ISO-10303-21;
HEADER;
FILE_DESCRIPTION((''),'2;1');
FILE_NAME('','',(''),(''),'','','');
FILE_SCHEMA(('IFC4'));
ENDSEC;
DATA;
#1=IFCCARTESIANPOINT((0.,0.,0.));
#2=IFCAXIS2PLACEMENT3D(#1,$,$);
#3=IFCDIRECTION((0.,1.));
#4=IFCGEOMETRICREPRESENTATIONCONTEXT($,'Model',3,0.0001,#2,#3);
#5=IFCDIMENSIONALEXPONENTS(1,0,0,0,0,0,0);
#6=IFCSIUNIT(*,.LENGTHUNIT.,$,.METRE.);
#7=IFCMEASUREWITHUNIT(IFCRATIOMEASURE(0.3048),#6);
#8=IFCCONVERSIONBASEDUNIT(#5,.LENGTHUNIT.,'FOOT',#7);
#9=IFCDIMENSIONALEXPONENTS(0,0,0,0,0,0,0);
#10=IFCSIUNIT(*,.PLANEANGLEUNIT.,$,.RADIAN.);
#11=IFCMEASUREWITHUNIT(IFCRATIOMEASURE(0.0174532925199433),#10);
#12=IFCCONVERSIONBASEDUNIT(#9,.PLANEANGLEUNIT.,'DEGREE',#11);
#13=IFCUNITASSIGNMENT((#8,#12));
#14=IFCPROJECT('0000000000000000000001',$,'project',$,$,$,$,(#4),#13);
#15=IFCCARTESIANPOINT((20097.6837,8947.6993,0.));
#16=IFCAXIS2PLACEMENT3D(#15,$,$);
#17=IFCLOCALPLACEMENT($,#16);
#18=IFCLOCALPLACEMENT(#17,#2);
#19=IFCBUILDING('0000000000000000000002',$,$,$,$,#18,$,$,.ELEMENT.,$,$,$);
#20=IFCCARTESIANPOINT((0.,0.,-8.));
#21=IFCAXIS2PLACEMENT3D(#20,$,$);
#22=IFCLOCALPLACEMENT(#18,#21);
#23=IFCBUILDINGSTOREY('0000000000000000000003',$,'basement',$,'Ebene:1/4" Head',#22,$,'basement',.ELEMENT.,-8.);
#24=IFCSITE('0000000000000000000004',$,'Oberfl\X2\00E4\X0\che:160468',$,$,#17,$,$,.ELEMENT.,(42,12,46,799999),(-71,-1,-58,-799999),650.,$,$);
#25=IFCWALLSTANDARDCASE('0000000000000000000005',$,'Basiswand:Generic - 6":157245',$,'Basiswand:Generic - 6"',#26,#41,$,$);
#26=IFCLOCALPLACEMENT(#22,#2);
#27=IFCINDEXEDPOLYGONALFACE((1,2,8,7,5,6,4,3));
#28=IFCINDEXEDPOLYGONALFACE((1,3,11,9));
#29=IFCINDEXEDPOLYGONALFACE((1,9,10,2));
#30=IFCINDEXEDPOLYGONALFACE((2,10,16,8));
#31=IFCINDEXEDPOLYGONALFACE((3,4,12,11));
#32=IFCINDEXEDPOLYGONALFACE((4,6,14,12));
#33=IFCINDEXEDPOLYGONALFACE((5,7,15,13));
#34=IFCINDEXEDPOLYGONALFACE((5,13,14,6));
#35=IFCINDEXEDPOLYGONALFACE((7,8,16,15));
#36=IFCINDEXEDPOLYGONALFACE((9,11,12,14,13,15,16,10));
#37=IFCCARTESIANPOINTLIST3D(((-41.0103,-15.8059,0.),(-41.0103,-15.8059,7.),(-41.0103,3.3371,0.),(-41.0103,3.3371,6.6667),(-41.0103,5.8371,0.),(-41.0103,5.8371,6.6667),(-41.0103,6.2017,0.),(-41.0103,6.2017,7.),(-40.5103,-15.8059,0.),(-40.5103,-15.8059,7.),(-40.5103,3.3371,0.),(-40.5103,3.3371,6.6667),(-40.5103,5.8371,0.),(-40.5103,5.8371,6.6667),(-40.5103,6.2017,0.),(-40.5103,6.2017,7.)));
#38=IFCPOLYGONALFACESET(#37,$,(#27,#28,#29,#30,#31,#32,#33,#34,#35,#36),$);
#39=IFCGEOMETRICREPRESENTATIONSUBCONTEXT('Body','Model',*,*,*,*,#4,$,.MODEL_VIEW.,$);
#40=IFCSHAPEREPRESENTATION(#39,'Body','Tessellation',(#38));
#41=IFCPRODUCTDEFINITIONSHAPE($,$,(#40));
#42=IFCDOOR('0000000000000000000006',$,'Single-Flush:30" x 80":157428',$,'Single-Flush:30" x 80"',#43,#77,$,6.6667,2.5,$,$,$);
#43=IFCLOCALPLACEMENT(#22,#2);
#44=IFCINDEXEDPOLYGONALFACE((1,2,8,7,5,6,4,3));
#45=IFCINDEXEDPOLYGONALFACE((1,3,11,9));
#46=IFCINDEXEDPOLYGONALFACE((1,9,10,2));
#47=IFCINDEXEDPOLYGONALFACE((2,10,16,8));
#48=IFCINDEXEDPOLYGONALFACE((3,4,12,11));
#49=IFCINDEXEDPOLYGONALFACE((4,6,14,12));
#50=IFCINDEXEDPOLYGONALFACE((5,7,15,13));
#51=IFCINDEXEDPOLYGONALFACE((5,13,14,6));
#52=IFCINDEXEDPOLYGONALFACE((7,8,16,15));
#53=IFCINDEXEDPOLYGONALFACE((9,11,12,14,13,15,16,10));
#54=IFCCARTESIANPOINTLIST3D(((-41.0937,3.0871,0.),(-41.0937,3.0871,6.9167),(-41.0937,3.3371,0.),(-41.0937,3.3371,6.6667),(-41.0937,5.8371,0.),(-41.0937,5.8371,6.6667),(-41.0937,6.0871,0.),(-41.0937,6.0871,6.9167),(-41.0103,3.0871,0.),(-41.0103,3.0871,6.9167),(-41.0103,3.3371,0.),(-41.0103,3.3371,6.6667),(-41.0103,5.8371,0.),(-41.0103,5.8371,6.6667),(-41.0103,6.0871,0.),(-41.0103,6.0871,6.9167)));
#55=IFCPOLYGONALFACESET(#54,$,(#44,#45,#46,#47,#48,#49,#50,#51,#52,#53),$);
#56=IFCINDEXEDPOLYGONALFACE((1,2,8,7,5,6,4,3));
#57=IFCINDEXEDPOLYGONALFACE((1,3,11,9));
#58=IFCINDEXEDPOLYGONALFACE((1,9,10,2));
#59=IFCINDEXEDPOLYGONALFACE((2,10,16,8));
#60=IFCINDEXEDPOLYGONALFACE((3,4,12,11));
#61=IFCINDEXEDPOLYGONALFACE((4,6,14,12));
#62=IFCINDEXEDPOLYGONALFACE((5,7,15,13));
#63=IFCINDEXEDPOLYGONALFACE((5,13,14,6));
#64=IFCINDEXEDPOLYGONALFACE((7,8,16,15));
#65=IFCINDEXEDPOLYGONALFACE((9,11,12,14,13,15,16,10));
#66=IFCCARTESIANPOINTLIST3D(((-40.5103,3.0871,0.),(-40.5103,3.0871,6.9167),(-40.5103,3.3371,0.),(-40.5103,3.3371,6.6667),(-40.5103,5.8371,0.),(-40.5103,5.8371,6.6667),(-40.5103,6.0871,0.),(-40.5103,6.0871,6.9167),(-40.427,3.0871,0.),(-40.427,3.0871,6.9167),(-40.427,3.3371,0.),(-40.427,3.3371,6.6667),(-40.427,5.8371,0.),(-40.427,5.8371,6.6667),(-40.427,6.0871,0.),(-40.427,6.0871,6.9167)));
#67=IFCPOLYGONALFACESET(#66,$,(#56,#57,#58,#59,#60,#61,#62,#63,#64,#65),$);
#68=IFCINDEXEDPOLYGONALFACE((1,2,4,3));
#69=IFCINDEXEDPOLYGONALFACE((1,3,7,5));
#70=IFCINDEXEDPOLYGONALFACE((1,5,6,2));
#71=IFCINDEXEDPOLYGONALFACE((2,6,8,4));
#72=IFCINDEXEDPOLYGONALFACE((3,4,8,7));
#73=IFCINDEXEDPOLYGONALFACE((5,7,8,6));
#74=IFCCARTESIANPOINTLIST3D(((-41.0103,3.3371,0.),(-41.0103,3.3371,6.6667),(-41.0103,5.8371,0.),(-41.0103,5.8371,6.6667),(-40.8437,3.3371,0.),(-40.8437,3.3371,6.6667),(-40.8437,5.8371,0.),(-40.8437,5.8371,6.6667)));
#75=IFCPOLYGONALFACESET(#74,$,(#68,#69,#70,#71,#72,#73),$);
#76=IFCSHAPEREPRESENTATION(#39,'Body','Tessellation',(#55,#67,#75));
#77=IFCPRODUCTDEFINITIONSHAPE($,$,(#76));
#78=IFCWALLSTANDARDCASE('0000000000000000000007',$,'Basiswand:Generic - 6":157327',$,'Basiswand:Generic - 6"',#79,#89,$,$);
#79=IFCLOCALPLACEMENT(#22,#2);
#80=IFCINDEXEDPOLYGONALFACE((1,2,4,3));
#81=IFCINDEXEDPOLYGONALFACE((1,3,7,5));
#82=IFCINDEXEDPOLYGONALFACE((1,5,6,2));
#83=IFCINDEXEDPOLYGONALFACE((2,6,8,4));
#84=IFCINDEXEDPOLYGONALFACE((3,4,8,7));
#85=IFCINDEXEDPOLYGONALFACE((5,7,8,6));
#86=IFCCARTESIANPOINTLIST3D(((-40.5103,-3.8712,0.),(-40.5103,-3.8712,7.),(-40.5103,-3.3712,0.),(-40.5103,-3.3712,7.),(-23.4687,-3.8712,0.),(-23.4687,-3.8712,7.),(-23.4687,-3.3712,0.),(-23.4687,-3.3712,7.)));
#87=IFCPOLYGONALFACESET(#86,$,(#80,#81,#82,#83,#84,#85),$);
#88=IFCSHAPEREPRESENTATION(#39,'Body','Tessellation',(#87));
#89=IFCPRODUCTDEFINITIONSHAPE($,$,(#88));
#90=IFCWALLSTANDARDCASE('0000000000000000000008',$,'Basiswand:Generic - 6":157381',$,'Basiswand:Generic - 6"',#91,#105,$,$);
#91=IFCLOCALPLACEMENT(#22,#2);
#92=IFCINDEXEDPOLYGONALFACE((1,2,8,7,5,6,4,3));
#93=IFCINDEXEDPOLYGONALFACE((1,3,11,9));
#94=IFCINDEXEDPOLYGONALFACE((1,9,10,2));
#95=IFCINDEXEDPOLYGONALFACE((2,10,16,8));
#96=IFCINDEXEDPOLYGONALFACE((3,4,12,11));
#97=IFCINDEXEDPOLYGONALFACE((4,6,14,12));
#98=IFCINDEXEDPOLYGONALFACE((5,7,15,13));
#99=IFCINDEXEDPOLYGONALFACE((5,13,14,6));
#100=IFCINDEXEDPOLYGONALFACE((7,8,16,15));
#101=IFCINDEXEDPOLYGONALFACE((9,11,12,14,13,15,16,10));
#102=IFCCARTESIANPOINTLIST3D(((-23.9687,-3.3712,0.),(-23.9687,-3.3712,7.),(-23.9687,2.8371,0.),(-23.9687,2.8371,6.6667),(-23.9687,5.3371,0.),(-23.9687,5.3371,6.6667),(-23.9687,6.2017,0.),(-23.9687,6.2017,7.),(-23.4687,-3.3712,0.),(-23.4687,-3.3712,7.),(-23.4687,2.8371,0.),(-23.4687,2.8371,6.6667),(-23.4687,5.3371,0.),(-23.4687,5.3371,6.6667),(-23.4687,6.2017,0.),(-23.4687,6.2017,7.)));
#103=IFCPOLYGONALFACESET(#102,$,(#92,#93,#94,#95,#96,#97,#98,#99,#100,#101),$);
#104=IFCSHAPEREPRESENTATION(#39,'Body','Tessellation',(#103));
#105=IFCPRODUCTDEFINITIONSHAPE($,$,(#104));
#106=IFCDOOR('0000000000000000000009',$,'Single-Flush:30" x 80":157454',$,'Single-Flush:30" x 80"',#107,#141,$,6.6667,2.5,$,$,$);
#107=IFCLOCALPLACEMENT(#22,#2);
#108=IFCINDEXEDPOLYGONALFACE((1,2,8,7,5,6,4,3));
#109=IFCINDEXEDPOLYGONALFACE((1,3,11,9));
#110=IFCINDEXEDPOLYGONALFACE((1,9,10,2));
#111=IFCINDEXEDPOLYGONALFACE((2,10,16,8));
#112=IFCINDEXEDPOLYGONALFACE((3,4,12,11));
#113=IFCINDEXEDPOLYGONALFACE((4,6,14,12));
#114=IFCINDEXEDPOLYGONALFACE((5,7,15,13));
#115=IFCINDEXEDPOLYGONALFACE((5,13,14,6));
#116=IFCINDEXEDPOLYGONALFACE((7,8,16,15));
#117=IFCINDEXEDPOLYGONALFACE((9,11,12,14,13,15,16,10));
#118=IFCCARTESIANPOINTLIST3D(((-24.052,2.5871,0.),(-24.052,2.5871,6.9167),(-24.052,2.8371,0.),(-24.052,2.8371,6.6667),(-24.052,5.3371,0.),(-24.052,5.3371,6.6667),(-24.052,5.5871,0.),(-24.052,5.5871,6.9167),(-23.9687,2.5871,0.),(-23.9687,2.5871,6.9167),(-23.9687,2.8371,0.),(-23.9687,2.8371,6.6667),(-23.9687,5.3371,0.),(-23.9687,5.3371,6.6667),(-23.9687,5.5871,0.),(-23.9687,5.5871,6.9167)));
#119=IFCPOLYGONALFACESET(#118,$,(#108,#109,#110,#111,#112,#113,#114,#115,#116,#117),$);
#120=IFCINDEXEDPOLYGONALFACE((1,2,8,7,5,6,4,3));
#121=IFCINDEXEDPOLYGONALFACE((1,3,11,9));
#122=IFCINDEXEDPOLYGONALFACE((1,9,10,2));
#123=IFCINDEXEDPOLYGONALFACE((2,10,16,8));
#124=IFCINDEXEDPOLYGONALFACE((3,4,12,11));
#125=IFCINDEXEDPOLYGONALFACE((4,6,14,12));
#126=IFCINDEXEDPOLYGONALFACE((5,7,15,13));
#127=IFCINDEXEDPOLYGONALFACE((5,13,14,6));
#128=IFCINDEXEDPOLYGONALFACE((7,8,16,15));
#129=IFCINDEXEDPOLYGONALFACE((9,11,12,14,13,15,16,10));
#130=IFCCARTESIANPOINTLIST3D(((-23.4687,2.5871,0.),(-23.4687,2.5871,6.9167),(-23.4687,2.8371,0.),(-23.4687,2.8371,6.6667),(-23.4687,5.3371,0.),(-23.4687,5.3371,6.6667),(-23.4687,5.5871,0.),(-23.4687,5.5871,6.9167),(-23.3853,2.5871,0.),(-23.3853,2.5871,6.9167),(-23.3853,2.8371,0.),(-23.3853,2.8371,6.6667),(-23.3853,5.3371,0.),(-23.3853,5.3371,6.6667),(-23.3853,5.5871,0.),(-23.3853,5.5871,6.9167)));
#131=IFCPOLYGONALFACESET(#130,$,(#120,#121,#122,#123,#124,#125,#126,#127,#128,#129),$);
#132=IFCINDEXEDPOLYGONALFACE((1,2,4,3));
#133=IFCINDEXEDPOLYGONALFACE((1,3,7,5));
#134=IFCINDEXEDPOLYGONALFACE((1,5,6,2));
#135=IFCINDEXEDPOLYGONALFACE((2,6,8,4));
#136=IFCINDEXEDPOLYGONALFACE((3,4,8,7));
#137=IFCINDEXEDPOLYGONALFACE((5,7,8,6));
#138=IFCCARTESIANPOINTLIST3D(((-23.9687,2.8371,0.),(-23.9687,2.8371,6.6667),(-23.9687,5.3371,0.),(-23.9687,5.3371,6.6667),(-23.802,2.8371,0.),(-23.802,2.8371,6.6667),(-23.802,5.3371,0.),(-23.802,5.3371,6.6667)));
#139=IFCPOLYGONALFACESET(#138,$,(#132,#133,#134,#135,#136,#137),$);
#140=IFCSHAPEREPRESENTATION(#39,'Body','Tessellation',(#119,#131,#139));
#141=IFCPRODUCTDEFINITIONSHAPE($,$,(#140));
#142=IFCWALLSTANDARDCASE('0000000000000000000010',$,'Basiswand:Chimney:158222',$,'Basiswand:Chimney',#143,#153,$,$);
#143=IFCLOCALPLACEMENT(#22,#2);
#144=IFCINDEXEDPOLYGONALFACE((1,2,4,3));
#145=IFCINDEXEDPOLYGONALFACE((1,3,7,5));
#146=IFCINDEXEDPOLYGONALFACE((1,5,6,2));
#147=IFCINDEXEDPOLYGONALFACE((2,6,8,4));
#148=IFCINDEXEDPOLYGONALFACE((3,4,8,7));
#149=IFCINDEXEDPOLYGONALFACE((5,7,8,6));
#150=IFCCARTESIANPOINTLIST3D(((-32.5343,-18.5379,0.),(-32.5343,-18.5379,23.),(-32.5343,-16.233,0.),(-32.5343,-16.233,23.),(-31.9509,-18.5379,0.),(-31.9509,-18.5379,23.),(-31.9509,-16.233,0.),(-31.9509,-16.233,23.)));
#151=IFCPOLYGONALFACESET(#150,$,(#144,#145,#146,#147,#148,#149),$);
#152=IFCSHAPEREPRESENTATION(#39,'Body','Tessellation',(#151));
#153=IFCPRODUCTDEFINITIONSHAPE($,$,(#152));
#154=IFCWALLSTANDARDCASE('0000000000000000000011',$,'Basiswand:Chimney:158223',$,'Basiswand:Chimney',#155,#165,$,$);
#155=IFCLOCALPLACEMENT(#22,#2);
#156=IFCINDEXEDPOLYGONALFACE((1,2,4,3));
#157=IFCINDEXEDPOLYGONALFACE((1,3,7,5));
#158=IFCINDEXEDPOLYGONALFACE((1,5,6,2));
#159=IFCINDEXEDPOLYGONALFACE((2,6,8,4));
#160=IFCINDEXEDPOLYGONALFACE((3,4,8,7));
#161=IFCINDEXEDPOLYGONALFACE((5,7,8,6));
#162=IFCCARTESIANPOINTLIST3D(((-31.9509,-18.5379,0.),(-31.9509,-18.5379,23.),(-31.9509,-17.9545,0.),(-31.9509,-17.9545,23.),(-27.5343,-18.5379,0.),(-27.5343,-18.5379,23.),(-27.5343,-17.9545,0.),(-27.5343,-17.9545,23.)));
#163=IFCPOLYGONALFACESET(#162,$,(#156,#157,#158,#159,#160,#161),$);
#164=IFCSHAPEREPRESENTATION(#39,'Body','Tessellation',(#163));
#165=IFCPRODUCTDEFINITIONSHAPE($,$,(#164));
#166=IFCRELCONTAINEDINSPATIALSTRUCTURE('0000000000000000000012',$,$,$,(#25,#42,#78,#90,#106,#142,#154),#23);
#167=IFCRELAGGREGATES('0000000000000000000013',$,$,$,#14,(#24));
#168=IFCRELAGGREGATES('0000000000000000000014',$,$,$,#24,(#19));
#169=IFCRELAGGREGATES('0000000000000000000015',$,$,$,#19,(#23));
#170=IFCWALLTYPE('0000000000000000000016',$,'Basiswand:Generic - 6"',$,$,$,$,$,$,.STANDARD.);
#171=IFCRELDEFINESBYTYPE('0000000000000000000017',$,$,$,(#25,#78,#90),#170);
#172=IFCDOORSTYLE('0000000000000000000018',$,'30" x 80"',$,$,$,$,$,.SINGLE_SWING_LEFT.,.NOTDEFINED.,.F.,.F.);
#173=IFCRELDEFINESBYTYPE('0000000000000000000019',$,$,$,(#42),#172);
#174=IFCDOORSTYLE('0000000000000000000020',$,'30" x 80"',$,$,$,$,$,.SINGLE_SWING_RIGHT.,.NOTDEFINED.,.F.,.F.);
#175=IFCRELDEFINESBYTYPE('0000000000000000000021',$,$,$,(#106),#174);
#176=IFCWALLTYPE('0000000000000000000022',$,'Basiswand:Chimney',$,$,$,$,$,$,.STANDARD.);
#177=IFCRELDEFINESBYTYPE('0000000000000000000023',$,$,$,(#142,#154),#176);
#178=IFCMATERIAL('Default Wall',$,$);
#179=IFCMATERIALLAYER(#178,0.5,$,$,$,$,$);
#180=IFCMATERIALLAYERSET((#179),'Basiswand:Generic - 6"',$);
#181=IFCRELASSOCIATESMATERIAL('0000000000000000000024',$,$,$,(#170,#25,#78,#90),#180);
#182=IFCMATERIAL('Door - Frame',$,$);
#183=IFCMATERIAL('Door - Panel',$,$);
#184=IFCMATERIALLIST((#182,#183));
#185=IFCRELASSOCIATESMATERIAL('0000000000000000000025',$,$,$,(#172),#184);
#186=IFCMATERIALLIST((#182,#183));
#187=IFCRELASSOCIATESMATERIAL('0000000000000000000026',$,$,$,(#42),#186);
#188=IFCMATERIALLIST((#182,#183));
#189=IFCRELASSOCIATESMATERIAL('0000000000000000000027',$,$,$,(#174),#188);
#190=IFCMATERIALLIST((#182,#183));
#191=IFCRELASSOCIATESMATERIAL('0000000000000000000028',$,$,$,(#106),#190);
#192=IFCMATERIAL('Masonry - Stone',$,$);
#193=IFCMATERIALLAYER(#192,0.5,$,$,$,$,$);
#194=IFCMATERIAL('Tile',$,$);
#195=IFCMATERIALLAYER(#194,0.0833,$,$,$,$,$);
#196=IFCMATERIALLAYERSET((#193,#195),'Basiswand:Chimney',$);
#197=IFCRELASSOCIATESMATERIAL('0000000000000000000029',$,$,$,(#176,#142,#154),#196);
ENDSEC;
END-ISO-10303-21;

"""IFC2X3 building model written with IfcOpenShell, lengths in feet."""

from ifc_helpers import new_model, entity, si_unit, converted_unit, direction, frame, frame_2d, origin, origin_2d_with_axis, place, context, subcontext, project, spatial, polyline, rectangle, outline, extrude, clip, bounded_halfspace, source, transform, mapped, material, material_list, layer, layer_set, layer_usage, type_object, type_shapes, element, fill, save


model = new_model("IFC2X3")

# Units and contexts
model_context = context("Model", 3, precision=0.0001, world=origin(), true_north=direction((0.0, 1.0)))
body_context = subcontext(model_context, "Body", "Model", "MODEL_VIEW")
ifc_project = project(units=[converted_unit("LENGTHUNIT", "FOOT", entity("IfcRatioMeasure", 0.3048), si_unit("LENGTHUNIT", "METRE"), dimensions=[1, 0, 0, 0, 0, 0, 0]), converted_unit("PLANEANGLEUNIT", "DEGREE", entity("IfcRatioMeasure", 0.0174532925199433), si_unit("PLANEANGLEUNIT", "RADIAN"), dimensions=[0, 0, 0, 0, 0, 0, 0])], contexts=[model_context])

# Site, building, storey
site_placement = place(None, frame((20097.6837, 8947.6993, 0.0)))
site = spatial("IfcSite", under=ifc_project, at=site_placement, Name="Oberfläche:160468", CompositionType="ELEMENT", RefLatitude=(42, 12, 46, 799999), RefLongitude=(-71, -1, -58, -799999), RefElevation=650.0)
building_placement = place(site_placement, origin())
building = spatial("IfcBuilding", under=site, at=building_placement, CompositionType="ELEMENT")
storey_placement = place(building_placement, frame((0.0, 0.0, -8.0)))
storey = spatial("IfcBuildingStorey", under=building, at=storey_placement, Name="basement", ObjectType="Ebene:1/4\" Head", LongName="basement", CompositionType="ELEMENT", Elevation=-8.0)

# Shared definitions
ifc_material_1 = material(Name="Door - Frame")
ifc_material_2 = material(Name="Door - Panel")

# Wall, opening, door
ifc_material_3 = material(Name="Default Wall")
ifc_layer_1 = layer(ifc_material_3, 0.5)
ifc_layer_set_1 = layer_set([ifc_layer_1], Name="Basiswand:Generic - 6\"")
ifc_layer_usage_1 = layer_usage(ifc_layer_set_1, "AXIS2", "NEGATIVE", 0.25)
wall_type_1 = type_object("IfcWallType", Name="Basiswand:Generic - 6\"", PredefinedType="STANDARD", material=ifc_layer_set_1)
wall_1_placement = place(storey_placement, frame((-40.7603, -15.8059, 0.0), z_axis=(0.0, 0.0, 1.0), x_axis=(0.0, 1.0, 0.0)))
wall_1 = element("IfcWallStandardCase", 1, at=wall_1_placement, inside=storey, type_object=wall_type_1, material=ifc_layer_usage_1, Name="Basiswand:Generic - 6\":157245", ObjectType="Basiswand:Generic - 6\"", context=body_context, shape_type="Clipping", body=[
    clip(extrude(rectangle(XDim=22.0076, YDim=0.5, at=frame_2d((11.0038, 0.0), x_axis=(-1.0, 0.0))), origin(), (0.0, 0.0, 1.0), 7.0), bounded_halfspace(frame((0.0, -0.25, 7.0), z_axis=(0.0, 0.0, -1.0), x_axis=(0.0, -1.0, 0.0)), True, frame((0.0, -0.25, 7.0)), polyline([(0.0, 0.0), (11.9347, 0.0), (12.4347, 0.0), (22.0076, 0.0), (22.0076, 0.5), (0.0, 0.5), (0.0, 0.0)]))),
])
opening_1_placement = place(wall_1_placement, frame((19.143, -0.25, 0.0)))
opening_1 = element("IfcOpeningElement", 2, at=opening_1_placement, cuts=wall_1, ObjectType="Opening", context=body_context, shape_type="SweptSolid", body=[
    extrude(rectangle(XDim=2.5, YDim=6.6667, at=frame_2d((3.3333, 1.25), x_axis=(0.0, -1.0))), frame((0.0, 0.0, 0.0), z_axis=(0.0, 1.0, 0.0), x_axis=(0.0, 0.0, 1.0)), (0.0, 0.0, 1.0), 0.5),
])
ifc_material_list_1 = material_list([ifc_material_1, ifc_material_2])
ifc_material_list_2 = material_list([ifc_material_1, ifc_material_2])
door_style_1 = type_object("IfcDoorStyle", Name="30\" x 80\"", ConstructionType="NOTDEFINED", OperationType="SINGLE_SWING_LEFT", ParameterTakesPrecedence=False, Sizeable=False, material=ifc_material_list_2)
shared_shape_1 = source(origin(), body_context, "Body", "SweptSolid", [
    extrude(outline(polyline([(-1.5, -3.5208), (1.5, -3.5208), (1.5, 3.3958), (1.25, 3.3958), (1.25, -3.2708), (-1.25, -3.2708), (-1.25, 3.3958), (-1.5, 3.3958), (-1.5, -3.5208)])), frame((1.25, 0.5833, 3.3958), z_axis=(0.0, -1.0, 0.0), x_axis=(-1.0, 0.0, 0.0)), (0.0, 0.0, 1.0), 0.0833),
    extrude(outline(polyline([(-3.5208, -1.5), (3.3958, -1.5), (3.3958, -1.25), (-3.2708, -1.25), (-3.2708, 1.25), (3.3958, 1.25), (3.3958, 1.5), (-3.5208, 1.5), (-3.5208, -1.5)])), frame((1.25, 0.0, 3.3958), z_axis=(0.0, -1.0, 0.0), x_axis=(0.0, 0.0, -1.0)), (0.0, 0.0, 1.0), 0.0833),
    extrude(rectangle(XDim=2.5, YDim=0.1667, at=origin_2d_with_axis()), frame((1.25, 0.4167, 0.0)), (0.0, 0.0, 1.0), 6.6667),
])
type_shapes(door_style_1, [shared_shape_1])
door_1_placement = place(opening_1_placement, origin())
door_1 = element("IfcDoor", 3, at=door_1_placement, inside=storey, type_object=door_style_1, material=ifc_material_list_1, Name="Single-Flush:30\" x 80\":157428", ObjectType="Single-Flush:30\" x 80\"", OverallHeight=6.6667, OverallWidth=2.5, context=body_context, shape_type="MappedRepresentation", body=[
    mapped(shared_shape_1, transform((0.0, 0.0, 0.0), scale=1.0)),
])
fill(opening_1, door_1)

# Wall
ifc_layer_usage_2 = layer_usage(ifc_layer_set_1, "AXIS2", "NEGATIVE", 0.25)
wall_2_placement = place(storey_placement, frame((-23.4687, -3.6212, 0.0), z_axis=(0.0, 0.0, 1.0), x_axis=(-1.0, 0.0, 0.0)))
element("IfcWallStandardCase", 4, at=wall_2_placement, inside=storey, type_object=wall_type_1, material=ifc_layer_usage_2, Name="Basiswand:Generic - 6\":157327", ObjectType="Basiswand:Generic - 6\"", context=body_context, shape_type="Clipping", body=[
    clip(extrude(rectangle(XDim=17.0417, YDim=0.5, at=frame_2d((8.5208, 0.0), x_axis=(-1.0, 0.0))), origin(), (0.0, 0.0, 1.0), 7.0), bounded_halfspace(frame((0.0, -0.25, 7.0), z_axis=(0.0, 0.0, -1.0), x_axis=(-1.0, 0.0, 0.0)), True, frame((0.0, -0.25, 7.0)), polyline([(0.0, 0.0), (0.5, 0.0), (17.0417, 0.0), (17.0417, 0.5), (0.0, 0.5), (0.0, 0.0)]))),
])

# Wall, opening, door
ifc_layer_usage_3 = layer_usage(ifc_layer_set_1, "AXIS2", "NEGATIVE", 0.25)
wall_3_placement = place(storey_placement, frame((-23.7187, -3.3712, 0.0), z_axis=(0.0, 0.0, 1.0), x_axis=(0.0, 1.0, 0.0)))
wall_3 = element("IfcWallStandardCase", 5, at=wall_3_placement, inside=storey, type_object=wall_type_1, material=ifc_layer_usage_3, Name="Basiswand:Generic - 6\":157381", ObjectType="Basiswand:Generic - 6\"", context=body_context, shape_type="Clipping", body=[
    clip(extrude(rectangle(XDim=9.5729, YDim=0.5, at=frame_2d((4.7865, 0.0), x_axis=(-1.0, 0.0))), origin(), (0.0, 0.0, 1.0), 7.0), bounded_halfspace(frame((0.0, -0.25, 7.0), z_axis=(0.0, 0.0, -1.0), x_axis=(0.0, -1.0, 0.0)), True, frame((0.0, -0.25, 7.0)), polyline([(0.0, 0.0), (9.5729, 0.0), (9.5729, 0.5), (0.0, 0.5), (0.0, 0.0)]))),
])
opening_2_placement = place(wall_3_placement, frame((6.2083, -0.25, 0.0)))
opening_2 = element("IfcOpeningElement", 6, at=opening_2_placement, cuts=wall_3, ObjectType="Opening", context=body_context, shape_type="SweptSolid", body=[
    extrude(rectangle(XDim=2.5, YDim=6.6667, at=frame_2d((3.3333, 1.25), x_axis=(0.0, 1.0))), frame((0.0, 0.0, 0.0), z_axis=(0.0, 1.0, 0.0), x_axis=(0.0, 0.0, 1.0)), (0.0, 0.0, 1.0), 0.5),
])
ifc_material_list_3 = material_list([ifc_material_1, ifc_material_2])
ifc_material_list_4 = material_list([ifc_material_1, ifc_material_2])
door_style_2 = type_object("IfcDoorStyle", Name="30\" x 80\"", ConstructionType="NOTDEFINED", OperationType="SINGLE_SWING_RIGHT", ParameterTakesPrecedence=False, Sizeable=False, material=ifc_material_list_4)
shared_shape_2 = source(origin(), body_context, "Body", "SweptSolid", [
    extrude(outline(polyline([(-1.5, -3.5208), (1.5, -3.5208), (1.5, 3.3958), (1.25, 3.3958), (1.25, -3.2708), (-1.25, -3.2708), (-1.25, 3.3958), (-1.5, 3.3958), (-1.5, -3.5208)])), frame((1.25, 0.5, 3.3958), z_axis=(0.0, 1.0, 0.0), x_axis=(1.0, 0.0, 0.0)), (0.0, 0.0, 1.0), 0.0833),
    extrude(outline(polyline([(-3.5208, -1.5), (3.3958, -1.5), (3.3958, -1.25), (-3.2708, -1.25), (-3.2708, 1.25), (3.3958, 1.25), (3.3958, 1.5), (-3.5208, 1.5), (-3.5208, -1.5)])), frame((1.25, -0.0833, 3.3958), z_axis=(0.0, 1.0, 0.0), x_axis=(0.0, 0.0, -1.0)), (0.0, 0.0, 1.0), 0.0833),
    extrude(rectangle(XDim=0.1667, YDim=2.5, at=origin_2d_with_axis()), frame((1.25, 0.4167, 0.0), z_axis=(0.0, 0.0, 1.0), x_axis=(0.0, 1.0, 0.0)), (0.0, 0.0, 1.0), 6.6667),
])
type_shapes(door_style_2, [shared_shape_2])
door_2_placement = place(opening_2_placement, origin())
door_2 = element("IfcDoor", 7, at=door_2_placement, inside=storey, type_object=door_style_2, material=ifc_material_list_3, Name="Single-Flush:30\" x 80\":157454", ObjectType="Single-Flush:30\" x 80\"", OverallHeight=6.6667, OverallWidth=2.5, context=body_context, shape_type="MappedRepresentation", body=[
    mapped(shared_shape_2, transform((0.0, 0.0, 0.0), scale=1.0)),
])
fill(opening_2, door_2)

# Walls
ifc_material_4 = material(Name="Masonry - Stone")
ifc_layer_2 = layer(ifc_material_4, 0.5)
ifc_material_5 = material(Name="Tile")
ifc_layer_3 = layer(ifc_material_5, 0.0833)
ifc_layer_set_2 = layer_set([ifc_layer_2, ifc_layer_3], Name="Basiswand:Chimney")
ifc_layer_usage_4 = layer_usage(ifc_layer_set_2, "AXIS2", "NEGATIVE", 0.2917)
wall_type_2 = type_object("IfcWallType", Name="Basiswand:Chimney", PredefinedType="STANDARD", material=ifc_layer_set_2)
wall_4_placement = place(storey_placement, frame((-32.2426, -18.5379, 0.0), z_axis=(0.0, 0.0, 1.0), x_axis=(0.0, 1.0, 0.0)))
element("IfcWallStandardCase", 8, at=wall_4_placement, inside=storey, type_object=wall_type_2, material=ifc_layer_usage_4, Name="Basiswand:Chimney:158222", ObjectType="Basiswand:Chimney", context=body_context, shape_type="SweptSolid", body=[
    extrude(rectangle(XDim=2.3049, YDim=0.5833, at=frame_2d((1.1525, 0.0), x_axis=(-1.0, 0.0))), origin(), (0.0, 0.0, 1.0), 23.0),
])
ifc_layer_usage_5 = layer_usage(ifc_layer_set_2, "AXIS2", "NEGATIVE", 0.2917)
wall_5_placement = place(storey_placement, frame((-27.5343, -18.2462, 0.0), z_axis=(0.0, 0.0, 1.0), x_axis=(-1.0, 0.0, 0.0)))
element("IfcWallStandardCase", 9, at=wall_5_placement, inside=storey, type_object=wall_type_2, material=ifc_layer_usage_5, Name="Basiswand:Chimney:158223", ObjectType="Basiswand:Chimney", context=body_context, shape_type="SweptSolid", body=[
    extrude(rectangle(XDim=4.4167, YDim=0.5833, at=frame_2d((2.2083, 0.0), x_axis=(-1.0, 0.0))), origin(), (0.0, 0.0, 1.0), 23.0),
])

save(model, "model.ifc")
